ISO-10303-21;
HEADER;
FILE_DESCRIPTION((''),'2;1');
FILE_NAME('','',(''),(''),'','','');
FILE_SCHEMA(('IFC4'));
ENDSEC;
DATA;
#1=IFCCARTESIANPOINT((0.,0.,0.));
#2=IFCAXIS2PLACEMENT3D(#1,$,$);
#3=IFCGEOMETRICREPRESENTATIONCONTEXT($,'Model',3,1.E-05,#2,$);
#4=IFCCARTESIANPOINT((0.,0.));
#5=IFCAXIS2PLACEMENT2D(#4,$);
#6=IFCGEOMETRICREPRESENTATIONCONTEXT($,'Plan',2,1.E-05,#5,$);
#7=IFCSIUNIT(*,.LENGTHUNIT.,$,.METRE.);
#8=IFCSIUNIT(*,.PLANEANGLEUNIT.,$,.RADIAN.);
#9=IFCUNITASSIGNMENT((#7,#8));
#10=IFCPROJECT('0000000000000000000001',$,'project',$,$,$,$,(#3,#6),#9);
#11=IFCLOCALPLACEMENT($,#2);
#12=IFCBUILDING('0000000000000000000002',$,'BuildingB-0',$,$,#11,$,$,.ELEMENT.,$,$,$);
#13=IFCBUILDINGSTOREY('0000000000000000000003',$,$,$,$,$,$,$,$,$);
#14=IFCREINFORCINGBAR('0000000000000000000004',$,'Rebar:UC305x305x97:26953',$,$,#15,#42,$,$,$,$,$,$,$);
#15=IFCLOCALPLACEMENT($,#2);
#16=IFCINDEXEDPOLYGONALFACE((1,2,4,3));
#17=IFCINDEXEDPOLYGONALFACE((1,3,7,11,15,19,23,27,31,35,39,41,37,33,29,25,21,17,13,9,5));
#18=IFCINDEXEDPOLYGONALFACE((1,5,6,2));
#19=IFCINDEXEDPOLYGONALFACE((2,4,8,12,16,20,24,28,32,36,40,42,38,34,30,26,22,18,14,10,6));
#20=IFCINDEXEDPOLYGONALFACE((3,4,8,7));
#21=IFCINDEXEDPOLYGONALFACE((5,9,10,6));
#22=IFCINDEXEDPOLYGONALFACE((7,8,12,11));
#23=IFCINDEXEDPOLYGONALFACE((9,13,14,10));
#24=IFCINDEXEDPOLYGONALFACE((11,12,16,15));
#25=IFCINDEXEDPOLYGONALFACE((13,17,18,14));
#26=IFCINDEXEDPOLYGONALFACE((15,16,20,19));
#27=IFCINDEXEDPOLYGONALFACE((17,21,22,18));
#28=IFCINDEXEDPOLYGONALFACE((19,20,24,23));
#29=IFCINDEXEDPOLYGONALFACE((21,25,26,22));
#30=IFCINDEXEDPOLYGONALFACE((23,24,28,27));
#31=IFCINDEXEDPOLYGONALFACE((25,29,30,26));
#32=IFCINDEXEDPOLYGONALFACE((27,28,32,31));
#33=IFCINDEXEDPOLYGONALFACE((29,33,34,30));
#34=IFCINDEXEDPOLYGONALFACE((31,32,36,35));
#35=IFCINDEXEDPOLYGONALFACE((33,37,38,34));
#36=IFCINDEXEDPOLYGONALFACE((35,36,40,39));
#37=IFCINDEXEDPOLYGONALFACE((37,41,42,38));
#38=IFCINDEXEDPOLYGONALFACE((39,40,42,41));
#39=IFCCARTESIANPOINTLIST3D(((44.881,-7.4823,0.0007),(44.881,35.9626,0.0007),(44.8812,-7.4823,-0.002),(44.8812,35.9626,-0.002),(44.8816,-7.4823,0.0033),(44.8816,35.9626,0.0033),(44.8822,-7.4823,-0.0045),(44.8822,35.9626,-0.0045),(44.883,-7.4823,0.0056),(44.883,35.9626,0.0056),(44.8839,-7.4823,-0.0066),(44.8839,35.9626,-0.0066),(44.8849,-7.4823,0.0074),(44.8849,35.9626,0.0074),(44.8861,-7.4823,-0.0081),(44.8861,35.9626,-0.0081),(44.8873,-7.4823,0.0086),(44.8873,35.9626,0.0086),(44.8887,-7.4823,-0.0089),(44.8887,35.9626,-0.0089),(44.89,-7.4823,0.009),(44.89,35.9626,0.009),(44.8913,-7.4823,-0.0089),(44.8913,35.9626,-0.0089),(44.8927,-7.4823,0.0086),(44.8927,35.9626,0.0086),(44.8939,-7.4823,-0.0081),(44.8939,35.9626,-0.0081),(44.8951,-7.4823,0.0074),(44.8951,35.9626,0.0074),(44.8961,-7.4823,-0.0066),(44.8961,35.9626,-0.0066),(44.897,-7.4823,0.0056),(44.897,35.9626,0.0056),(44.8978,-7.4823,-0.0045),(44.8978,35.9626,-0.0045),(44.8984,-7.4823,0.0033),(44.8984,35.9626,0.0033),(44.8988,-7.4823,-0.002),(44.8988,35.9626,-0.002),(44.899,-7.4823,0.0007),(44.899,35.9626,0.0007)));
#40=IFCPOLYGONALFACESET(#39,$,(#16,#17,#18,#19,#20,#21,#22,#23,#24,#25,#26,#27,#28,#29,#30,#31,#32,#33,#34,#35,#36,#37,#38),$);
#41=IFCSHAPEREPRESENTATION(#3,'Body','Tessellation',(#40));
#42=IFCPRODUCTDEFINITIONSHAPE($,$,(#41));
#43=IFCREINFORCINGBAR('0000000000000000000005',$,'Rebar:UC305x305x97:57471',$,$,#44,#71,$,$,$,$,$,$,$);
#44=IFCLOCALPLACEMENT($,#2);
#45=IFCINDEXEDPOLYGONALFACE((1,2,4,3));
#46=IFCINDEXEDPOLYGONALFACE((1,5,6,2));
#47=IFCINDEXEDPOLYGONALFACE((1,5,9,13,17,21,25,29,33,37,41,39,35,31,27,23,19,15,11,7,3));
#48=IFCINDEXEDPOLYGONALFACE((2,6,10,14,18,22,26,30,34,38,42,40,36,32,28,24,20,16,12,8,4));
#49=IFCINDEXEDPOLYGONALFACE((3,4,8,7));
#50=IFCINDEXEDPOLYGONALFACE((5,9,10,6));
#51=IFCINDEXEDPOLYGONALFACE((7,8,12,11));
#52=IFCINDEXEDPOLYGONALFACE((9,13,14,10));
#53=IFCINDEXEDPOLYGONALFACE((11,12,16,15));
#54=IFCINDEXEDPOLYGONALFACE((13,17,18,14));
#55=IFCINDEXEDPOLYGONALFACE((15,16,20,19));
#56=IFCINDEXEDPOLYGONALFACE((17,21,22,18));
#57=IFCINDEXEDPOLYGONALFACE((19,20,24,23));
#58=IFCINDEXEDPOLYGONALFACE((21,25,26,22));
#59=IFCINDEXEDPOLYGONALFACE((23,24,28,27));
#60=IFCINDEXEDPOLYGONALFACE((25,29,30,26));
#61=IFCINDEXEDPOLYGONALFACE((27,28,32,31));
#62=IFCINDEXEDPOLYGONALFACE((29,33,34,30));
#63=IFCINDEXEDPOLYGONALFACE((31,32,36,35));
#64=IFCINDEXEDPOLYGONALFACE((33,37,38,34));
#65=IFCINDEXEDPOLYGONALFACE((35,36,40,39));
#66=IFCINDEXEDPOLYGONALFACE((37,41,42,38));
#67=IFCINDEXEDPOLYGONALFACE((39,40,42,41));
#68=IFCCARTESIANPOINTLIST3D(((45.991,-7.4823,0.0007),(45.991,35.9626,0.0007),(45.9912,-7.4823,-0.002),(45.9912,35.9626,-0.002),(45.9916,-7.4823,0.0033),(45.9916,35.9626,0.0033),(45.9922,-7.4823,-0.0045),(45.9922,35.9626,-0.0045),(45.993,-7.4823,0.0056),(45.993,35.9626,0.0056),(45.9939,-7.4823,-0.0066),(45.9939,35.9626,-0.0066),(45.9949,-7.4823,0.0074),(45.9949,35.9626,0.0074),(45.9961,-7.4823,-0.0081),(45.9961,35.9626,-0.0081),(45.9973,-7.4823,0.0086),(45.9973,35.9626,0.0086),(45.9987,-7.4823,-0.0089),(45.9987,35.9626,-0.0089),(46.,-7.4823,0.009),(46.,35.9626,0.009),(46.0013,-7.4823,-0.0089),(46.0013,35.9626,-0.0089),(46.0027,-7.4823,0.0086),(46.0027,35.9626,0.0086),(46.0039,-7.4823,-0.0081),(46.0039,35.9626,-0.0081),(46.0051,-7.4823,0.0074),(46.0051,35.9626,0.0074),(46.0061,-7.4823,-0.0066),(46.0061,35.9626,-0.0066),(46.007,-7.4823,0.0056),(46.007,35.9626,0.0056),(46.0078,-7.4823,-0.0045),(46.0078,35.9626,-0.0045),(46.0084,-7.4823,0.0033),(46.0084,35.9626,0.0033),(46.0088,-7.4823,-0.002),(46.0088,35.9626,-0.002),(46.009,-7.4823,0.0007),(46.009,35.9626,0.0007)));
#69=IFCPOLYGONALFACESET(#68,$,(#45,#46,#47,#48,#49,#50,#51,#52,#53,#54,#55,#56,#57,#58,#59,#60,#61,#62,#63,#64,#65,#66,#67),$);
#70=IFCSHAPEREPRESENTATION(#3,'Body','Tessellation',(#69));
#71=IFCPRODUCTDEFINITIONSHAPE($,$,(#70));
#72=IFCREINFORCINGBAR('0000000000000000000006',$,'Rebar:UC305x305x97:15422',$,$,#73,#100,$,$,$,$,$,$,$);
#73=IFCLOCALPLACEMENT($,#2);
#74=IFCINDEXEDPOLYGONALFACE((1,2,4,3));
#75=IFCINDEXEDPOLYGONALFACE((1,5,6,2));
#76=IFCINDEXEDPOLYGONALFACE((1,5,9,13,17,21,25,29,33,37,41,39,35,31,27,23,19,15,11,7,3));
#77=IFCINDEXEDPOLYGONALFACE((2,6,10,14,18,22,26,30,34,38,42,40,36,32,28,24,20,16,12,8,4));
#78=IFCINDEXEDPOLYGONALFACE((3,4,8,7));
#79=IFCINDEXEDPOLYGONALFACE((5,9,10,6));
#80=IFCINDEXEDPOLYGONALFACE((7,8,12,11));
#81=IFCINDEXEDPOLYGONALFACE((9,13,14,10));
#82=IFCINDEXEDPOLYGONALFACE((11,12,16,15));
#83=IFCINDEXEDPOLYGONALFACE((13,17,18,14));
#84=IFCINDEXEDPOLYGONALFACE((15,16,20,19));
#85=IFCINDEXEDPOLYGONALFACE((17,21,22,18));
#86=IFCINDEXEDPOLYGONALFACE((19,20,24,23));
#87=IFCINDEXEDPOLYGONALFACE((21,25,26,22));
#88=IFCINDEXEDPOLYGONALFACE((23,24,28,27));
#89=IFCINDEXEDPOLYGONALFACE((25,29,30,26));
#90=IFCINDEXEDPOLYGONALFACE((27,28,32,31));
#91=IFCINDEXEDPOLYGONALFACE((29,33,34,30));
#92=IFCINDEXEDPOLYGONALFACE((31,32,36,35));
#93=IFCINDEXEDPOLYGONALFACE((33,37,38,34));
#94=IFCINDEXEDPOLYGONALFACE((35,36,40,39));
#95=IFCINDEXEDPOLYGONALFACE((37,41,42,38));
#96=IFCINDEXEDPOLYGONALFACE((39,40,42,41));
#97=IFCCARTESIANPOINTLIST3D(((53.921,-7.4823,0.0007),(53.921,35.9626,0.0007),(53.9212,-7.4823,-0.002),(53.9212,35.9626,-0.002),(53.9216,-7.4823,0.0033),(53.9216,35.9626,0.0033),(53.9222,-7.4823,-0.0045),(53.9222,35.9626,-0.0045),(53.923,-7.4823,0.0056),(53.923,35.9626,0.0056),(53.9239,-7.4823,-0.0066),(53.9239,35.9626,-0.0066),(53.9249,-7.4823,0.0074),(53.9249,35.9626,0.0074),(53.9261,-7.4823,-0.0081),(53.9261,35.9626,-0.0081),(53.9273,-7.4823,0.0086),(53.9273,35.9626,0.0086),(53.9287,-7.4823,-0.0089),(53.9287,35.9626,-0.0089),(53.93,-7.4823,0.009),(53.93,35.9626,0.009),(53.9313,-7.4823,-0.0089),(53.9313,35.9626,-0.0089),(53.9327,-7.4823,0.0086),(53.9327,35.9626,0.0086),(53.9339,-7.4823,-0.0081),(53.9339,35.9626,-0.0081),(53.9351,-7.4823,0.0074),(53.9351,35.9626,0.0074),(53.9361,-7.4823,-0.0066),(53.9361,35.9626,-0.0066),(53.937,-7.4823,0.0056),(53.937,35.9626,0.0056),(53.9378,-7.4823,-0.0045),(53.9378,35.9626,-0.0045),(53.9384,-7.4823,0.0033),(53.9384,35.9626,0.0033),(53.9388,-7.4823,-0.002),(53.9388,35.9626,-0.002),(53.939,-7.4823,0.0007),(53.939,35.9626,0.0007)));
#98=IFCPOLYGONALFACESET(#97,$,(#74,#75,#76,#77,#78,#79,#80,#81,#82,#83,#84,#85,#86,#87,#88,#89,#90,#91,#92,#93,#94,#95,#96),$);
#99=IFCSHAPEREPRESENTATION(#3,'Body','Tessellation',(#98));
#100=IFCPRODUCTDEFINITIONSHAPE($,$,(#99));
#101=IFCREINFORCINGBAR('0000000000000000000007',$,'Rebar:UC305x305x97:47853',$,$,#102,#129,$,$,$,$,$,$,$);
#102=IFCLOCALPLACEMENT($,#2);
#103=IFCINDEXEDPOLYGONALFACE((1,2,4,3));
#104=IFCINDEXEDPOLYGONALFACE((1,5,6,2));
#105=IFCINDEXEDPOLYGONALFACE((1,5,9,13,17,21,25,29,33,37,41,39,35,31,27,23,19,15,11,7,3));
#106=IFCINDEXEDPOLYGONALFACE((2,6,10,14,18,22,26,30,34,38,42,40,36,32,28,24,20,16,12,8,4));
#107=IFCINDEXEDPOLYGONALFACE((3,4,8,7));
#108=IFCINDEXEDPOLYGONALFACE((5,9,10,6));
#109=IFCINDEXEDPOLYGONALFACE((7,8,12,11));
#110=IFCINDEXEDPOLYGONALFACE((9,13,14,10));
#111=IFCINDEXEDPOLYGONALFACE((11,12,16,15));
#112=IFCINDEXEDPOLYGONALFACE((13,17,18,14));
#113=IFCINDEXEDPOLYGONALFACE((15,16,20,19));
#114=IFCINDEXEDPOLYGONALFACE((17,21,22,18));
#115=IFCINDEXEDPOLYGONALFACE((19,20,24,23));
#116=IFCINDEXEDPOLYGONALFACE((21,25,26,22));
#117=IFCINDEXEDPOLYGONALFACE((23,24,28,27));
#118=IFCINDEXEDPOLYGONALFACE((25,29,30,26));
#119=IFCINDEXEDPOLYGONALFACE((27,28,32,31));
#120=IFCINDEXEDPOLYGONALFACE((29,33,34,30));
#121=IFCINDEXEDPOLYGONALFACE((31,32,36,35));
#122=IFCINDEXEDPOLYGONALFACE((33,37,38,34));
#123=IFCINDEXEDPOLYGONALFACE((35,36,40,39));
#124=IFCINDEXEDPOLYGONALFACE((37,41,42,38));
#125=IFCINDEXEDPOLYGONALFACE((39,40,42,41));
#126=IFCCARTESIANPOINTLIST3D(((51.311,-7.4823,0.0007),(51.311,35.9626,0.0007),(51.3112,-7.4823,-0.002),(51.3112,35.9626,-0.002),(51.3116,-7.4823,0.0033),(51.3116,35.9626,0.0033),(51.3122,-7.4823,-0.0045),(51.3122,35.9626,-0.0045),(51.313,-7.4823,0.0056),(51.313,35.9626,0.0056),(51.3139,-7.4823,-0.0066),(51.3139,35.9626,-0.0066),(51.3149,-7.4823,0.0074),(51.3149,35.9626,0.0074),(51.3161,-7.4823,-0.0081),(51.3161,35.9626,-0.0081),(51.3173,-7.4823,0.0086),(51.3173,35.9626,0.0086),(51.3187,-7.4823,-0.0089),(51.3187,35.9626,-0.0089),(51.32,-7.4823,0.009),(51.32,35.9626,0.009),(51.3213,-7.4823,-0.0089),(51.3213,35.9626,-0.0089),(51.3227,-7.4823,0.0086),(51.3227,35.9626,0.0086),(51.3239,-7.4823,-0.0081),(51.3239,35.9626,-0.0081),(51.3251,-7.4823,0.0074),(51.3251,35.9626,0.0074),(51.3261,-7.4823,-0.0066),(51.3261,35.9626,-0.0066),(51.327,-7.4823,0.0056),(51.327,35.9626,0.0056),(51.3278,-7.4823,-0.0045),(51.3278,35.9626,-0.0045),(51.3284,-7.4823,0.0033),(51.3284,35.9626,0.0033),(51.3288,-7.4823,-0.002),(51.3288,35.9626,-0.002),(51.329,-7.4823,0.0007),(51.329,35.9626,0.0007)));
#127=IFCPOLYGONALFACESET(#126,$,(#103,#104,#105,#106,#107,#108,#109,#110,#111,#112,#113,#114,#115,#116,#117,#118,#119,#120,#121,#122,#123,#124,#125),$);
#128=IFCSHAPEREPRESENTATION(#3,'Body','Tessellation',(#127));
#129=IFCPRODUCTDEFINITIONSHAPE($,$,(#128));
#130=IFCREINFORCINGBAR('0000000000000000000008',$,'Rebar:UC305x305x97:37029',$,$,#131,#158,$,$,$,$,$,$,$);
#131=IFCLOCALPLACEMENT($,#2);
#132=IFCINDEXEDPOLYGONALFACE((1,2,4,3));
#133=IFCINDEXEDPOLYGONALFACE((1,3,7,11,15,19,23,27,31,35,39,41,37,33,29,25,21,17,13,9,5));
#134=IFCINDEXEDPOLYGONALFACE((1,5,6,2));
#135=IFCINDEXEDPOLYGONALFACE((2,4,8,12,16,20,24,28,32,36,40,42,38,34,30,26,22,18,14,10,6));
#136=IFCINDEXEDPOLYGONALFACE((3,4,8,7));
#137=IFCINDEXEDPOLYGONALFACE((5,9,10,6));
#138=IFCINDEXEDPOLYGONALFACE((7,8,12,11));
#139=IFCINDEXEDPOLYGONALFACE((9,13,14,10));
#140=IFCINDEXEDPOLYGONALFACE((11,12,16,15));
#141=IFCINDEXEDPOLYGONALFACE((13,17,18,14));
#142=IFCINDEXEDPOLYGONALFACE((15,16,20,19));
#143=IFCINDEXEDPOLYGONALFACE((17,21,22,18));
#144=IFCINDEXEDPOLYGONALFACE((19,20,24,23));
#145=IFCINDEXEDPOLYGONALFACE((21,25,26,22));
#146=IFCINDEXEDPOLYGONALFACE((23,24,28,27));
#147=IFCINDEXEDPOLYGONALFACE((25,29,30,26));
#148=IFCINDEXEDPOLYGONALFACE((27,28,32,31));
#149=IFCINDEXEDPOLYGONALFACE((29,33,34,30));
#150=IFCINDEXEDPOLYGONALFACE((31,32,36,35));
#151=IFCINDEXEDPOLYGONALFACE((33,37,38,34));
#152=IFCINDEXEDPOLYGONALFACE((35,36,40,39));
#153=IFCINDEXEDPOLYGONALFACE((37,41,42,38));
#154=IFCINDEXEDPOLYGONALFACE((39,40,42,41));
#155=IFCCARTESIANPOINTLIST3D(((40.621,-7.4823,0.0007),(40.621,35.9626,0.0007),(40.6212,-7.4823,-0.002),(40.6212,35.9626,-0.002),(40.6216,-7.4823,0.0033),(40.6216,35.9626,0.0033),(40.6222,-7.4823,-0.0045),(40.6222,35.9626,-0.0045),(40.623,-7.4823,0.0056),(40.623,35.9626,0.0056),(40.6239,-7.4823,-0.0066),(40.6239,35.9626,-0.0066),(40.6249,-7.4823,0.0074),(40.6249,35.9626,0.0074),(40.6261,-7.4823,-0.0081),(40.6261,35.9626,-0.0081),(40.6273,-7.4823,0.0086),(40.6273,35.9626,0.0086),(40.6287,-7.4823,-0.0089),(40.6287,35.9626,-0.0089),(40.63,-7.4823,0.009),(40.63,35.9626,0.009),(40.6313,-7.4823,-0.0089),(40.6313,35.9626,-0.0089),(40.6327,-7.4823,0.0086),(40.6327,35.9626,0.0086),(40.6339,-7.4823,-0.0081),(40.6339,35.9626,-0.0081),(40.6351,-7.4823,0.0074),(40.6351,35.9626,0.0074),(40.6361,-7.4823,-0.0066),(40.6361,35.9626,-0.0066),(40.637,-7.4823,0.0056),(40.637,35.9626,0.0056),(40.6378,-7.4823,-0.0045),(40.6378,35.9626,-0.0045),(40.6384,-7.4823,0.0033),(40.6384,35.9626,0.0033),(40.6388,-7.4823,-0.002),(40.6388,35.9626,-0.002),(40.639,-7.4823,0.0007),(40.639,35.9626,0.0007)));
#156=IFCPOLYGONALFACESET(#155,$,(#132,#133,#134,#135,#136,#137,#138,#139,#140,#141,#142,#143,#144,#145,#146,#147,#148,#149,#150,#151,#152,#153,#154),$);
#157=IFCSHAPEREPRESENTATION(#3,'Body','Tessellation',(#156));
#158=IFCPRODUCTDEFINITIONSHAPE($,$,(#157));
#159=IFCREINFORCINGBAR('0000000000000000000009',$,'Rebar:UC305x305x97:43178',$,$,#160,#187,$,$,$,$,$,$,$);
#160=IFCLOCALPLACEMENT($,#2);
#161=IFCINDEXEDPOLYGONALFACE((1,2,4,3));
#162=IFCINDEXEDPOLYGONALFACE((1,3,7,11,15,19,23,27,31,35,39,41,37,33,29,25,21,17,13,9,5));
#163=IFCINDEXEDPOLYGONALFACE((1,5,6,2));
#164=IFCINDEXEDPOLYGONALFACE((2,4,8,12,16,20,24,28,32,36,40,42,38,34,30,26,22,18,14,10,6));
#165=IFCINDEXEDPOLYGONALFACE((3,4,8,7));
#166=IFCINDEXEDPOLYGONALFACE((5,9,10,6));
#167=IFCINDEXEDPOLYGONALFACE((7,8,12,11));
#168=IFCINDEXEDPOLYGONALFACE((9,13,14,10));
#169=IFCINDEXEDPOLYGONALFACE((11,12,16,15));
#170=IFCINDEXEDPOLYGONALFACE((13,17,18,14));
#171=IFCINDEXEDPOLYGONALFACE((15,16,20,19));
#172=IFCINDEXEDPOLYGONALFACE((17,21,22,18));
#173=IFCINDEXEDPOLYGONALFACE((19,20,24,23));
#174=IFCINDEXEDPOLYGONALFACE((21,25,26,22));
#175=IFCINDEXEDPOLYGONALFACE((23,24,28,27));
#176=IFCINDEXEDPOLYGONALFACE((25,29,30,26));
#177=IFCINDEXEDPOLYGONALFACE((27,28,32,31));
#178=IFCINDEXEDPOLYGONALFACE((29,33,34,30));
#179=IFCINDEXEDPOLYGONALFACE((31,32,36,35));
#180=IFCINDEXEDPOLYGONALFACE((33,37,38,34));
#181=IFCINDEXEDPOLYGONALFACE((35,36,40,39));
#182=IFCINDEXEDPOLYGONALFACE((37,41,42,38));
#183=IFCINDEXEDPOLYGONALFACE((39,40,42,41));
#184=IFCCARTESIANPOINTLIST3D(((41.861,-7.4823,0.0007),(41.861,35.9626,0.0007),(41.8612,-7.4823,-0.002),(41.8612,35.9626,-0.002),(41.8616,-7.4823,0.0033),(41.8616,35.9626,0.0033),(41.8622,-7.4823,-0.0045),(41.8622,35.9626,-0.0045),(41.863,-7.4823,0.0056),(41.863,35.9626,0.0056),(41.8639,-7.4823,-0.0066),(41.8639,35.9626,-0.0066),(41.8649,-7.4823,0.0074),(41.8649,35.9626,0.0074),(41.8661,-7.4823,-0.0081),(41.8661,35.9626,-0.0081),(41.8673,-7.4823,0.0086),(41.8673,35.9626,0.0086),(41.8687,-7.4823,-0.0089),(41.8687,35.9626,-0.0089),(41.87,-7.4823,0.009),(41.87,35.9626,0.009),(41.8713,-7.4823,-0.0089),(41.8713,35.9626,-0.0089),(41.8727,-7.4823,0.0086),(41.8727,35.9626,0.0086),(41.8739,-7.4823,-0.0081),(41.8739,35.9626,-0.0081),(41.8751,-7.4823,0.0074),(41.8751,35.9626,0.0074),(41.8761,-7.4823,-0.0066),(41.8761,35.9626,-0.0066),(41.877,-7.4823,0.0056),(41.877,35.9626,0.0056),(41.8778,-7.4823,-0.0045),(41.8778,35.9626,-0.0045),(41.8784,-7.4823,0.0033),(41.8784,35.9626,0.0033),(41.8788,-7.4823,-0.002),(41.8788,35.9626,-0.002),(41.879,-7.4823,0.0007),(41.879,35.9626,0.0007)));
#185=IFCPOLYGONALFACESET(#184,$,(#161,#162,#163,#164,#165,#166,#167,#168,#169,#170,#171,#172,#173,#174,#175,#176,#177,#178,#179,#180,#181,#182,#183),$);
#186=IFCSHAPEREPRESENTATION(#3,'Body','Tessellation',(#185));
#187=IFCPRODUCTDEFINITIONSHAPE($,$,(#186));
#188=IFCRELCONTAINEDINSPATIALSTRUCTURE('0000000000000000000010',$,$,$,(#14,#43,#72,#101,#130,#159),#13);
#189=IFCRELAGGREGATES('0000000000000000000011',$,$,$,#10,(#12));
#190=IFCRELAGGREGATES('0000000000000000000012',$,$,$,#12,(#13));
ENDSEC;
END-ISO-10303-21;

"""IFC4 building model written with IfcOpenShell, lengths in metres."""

from ifc_helpers import new_model, entity, si_unit, origin, origin_2d, place, context, project, spatial, element, save


model = new_model("IFC4")

# Units and contexts
model_context = context("Model", 3, precision=1e-05, world=origin())
plan_context = context("Plan", 2, precision=1e-05, world=origin_2d())
ifc_project = project(units=[si_unit("LENGTHUNIT", "METRE"), si_unit("PLANEANGLEUNIT", "RADIAN")], contexts=[model_context, plan_context])

# Building, storey
building_placement = place(None, origin())
building = spatial("IfcBuilding", under=ifc_project, at=building_placement, Name="BuildingB-0", CompositionType="ELEMENT")
storey = spatial("IfcBuildingStorey", under=building)

# Reinforcing bars
element("IfcReinforcingBar", 1, inside=storey, Name="Rebar:UC305x305x97:26953", context=model_context, shape_type="SweptSolid", body=[
    entity("IfcSurfaceCurveSweptAreaSolid", entity("IfcCircleProfileDef", "AREA", None, None, 0.009), None, entity("IfcPolyline", [entity("IfcCartesianPoint", [44.89, 35.9626, 0.0]), entity("IfcCartesianPoint", [44.89, -7.4823, 0.0])]), None, None, entity("IfcPlane", entity("IfcAxis2Placement3D", entity("IfcCartesianPoint", [44.89, 35.9626, 0.0]), entity("IfcDirection", [0.0, 0.0, 1.0]), entity("IfcDirection", [1.0, 0.0, 0.0])))),
])
element("IfcReinforcingBar", 2, inside=storey, Name="Rebar:UC305x305x97:57471", context=model_context, shape_type="SweptSolid", body=[
    entity("IfcSurfaceCurveSweptAreaSolid", entity("IfcCircleProfileDef", "AREA", None, None, 0.009), None, entity("IfcPolyline", [entity("IfcCartesianPoint", [46.0, -7.4823, 0.0]), entity("IfcCartesianPoint", [46.0, 35.9626, 0.0])]), None, None, entity("IfcPlane", entity("IfcAxis2Placement3D", entity("IfcCartesianPoint", [46.0, -7.4823, 0.0]), entity("IfcDirection", [0.0, 0.0, 1.0]), entity("IfcDirection", [1.0, 0.0, 0.0])))),
])
element("IfcReinforcingBar", 3, inside=storey, Name="Rebar:UC305x305x97:15422", context=model_context, shape_type="SweptSolid", body=[
    entity("IfcSurfaceCurveSweptAreaSolid", entity("IfcCircleProfileDef", "AREA", None, None, 0.009), None, entity("IfcPolyline", [entity("IfcCartesianPoint", [53.93, -7.4823, 0.0]), entity("IfcCartesianPoint", [53.93, 35.9626, 0.0])]), None, None, entity("IfcPlane", entity("IfcAxis2Placement3D", entity("IfcCartesianPoint", [53.93, -7.4823, 0.0]), entity("IfcDirection", [0.0, 0.0, 1.0]), entity("IfcDirection", [1.0, 0.0, 0.0])))),
])
element("IfcReinforcingBar", 4, inside=storey, Name="Rebar:UC305x305x97:47853", context=model_context, shape_type="SweptSolid", body=[
    entity("IfcSurfaceCurveSweptAreaSolid", entity("IfcCircleProfileDef", "AREA", None, None, 0.009), None, entity("IfcPolyline", [entity("IfcCartesianPoint", [51.32, -7.4823, 0.0]), entity("IfcCartesianPoint", [51.32, 35.9626, 0.0])]), None, None, entity("IfcPlane", entity("IfcAxis2Placement3D", entity("IfcCartesianPoint", [51.32, -7.4823, 0.0]), entity("IfcDirection", [0.0, 0.0, 1.0]), entity("IfcDirection", [1.0, 0.0, 0.0])))),
])
element("IfcReinforcingBar", 5, inside=storey, Name="Rebar:UC305x305x97:37029", context=model_context, shape_type="SweptSolid", body=[
    entity("IfcSurfaceCurveSweptAreaSolid", entity("IfcCircleProfileDef", "AREA", None, None, 0.009), None, entity("IfcPolyline", [entity("IfcCartesianPoint", [40.63, 35.9626, 0.0]), entity("IfcCartesianPoint", [40.63, -7.4823, 0.0])]), None, None, entity("IfcPlane", entity("IfcAxis2Placement3D", entity("IfcCartesianPoint", [40.63, 35.9626, 0.0]), entity("IfcDirection", [0.0, 0.0, 1.0]), entity("IfcDirection", [1.0, 0.0, 0.0])))),
])
element("IfcReinforcingBar", 6, inside=storey, Name="Rebar:UC305x305x97:43178", context=model_context, shape_type="SweptSolid", body=[
    entity("IfcSurfaceCurveSweptAreaSolid", entity("IfcCircleProfileDef", "AREA", None, None, 0.009), None, entity("IfcPolyline", [entity("IfcCartesianPoint", [41.87, 35.9626, 0.0]), entity("IfcCartesianPoint", [41.87, -7.4823, 0.0])]), None, None, entity("IfcPlane", entity("IfcAxis2Placement3D", entity("IfcCartesianPoint", [41.87, 35.9626, 0.0]), entity("IfcDirection", [0.0, 0.0, 1.0]), entity("IfcDirection", [1.0, 0.0, 0.0])))),
])

save(model, "model.ifc")
